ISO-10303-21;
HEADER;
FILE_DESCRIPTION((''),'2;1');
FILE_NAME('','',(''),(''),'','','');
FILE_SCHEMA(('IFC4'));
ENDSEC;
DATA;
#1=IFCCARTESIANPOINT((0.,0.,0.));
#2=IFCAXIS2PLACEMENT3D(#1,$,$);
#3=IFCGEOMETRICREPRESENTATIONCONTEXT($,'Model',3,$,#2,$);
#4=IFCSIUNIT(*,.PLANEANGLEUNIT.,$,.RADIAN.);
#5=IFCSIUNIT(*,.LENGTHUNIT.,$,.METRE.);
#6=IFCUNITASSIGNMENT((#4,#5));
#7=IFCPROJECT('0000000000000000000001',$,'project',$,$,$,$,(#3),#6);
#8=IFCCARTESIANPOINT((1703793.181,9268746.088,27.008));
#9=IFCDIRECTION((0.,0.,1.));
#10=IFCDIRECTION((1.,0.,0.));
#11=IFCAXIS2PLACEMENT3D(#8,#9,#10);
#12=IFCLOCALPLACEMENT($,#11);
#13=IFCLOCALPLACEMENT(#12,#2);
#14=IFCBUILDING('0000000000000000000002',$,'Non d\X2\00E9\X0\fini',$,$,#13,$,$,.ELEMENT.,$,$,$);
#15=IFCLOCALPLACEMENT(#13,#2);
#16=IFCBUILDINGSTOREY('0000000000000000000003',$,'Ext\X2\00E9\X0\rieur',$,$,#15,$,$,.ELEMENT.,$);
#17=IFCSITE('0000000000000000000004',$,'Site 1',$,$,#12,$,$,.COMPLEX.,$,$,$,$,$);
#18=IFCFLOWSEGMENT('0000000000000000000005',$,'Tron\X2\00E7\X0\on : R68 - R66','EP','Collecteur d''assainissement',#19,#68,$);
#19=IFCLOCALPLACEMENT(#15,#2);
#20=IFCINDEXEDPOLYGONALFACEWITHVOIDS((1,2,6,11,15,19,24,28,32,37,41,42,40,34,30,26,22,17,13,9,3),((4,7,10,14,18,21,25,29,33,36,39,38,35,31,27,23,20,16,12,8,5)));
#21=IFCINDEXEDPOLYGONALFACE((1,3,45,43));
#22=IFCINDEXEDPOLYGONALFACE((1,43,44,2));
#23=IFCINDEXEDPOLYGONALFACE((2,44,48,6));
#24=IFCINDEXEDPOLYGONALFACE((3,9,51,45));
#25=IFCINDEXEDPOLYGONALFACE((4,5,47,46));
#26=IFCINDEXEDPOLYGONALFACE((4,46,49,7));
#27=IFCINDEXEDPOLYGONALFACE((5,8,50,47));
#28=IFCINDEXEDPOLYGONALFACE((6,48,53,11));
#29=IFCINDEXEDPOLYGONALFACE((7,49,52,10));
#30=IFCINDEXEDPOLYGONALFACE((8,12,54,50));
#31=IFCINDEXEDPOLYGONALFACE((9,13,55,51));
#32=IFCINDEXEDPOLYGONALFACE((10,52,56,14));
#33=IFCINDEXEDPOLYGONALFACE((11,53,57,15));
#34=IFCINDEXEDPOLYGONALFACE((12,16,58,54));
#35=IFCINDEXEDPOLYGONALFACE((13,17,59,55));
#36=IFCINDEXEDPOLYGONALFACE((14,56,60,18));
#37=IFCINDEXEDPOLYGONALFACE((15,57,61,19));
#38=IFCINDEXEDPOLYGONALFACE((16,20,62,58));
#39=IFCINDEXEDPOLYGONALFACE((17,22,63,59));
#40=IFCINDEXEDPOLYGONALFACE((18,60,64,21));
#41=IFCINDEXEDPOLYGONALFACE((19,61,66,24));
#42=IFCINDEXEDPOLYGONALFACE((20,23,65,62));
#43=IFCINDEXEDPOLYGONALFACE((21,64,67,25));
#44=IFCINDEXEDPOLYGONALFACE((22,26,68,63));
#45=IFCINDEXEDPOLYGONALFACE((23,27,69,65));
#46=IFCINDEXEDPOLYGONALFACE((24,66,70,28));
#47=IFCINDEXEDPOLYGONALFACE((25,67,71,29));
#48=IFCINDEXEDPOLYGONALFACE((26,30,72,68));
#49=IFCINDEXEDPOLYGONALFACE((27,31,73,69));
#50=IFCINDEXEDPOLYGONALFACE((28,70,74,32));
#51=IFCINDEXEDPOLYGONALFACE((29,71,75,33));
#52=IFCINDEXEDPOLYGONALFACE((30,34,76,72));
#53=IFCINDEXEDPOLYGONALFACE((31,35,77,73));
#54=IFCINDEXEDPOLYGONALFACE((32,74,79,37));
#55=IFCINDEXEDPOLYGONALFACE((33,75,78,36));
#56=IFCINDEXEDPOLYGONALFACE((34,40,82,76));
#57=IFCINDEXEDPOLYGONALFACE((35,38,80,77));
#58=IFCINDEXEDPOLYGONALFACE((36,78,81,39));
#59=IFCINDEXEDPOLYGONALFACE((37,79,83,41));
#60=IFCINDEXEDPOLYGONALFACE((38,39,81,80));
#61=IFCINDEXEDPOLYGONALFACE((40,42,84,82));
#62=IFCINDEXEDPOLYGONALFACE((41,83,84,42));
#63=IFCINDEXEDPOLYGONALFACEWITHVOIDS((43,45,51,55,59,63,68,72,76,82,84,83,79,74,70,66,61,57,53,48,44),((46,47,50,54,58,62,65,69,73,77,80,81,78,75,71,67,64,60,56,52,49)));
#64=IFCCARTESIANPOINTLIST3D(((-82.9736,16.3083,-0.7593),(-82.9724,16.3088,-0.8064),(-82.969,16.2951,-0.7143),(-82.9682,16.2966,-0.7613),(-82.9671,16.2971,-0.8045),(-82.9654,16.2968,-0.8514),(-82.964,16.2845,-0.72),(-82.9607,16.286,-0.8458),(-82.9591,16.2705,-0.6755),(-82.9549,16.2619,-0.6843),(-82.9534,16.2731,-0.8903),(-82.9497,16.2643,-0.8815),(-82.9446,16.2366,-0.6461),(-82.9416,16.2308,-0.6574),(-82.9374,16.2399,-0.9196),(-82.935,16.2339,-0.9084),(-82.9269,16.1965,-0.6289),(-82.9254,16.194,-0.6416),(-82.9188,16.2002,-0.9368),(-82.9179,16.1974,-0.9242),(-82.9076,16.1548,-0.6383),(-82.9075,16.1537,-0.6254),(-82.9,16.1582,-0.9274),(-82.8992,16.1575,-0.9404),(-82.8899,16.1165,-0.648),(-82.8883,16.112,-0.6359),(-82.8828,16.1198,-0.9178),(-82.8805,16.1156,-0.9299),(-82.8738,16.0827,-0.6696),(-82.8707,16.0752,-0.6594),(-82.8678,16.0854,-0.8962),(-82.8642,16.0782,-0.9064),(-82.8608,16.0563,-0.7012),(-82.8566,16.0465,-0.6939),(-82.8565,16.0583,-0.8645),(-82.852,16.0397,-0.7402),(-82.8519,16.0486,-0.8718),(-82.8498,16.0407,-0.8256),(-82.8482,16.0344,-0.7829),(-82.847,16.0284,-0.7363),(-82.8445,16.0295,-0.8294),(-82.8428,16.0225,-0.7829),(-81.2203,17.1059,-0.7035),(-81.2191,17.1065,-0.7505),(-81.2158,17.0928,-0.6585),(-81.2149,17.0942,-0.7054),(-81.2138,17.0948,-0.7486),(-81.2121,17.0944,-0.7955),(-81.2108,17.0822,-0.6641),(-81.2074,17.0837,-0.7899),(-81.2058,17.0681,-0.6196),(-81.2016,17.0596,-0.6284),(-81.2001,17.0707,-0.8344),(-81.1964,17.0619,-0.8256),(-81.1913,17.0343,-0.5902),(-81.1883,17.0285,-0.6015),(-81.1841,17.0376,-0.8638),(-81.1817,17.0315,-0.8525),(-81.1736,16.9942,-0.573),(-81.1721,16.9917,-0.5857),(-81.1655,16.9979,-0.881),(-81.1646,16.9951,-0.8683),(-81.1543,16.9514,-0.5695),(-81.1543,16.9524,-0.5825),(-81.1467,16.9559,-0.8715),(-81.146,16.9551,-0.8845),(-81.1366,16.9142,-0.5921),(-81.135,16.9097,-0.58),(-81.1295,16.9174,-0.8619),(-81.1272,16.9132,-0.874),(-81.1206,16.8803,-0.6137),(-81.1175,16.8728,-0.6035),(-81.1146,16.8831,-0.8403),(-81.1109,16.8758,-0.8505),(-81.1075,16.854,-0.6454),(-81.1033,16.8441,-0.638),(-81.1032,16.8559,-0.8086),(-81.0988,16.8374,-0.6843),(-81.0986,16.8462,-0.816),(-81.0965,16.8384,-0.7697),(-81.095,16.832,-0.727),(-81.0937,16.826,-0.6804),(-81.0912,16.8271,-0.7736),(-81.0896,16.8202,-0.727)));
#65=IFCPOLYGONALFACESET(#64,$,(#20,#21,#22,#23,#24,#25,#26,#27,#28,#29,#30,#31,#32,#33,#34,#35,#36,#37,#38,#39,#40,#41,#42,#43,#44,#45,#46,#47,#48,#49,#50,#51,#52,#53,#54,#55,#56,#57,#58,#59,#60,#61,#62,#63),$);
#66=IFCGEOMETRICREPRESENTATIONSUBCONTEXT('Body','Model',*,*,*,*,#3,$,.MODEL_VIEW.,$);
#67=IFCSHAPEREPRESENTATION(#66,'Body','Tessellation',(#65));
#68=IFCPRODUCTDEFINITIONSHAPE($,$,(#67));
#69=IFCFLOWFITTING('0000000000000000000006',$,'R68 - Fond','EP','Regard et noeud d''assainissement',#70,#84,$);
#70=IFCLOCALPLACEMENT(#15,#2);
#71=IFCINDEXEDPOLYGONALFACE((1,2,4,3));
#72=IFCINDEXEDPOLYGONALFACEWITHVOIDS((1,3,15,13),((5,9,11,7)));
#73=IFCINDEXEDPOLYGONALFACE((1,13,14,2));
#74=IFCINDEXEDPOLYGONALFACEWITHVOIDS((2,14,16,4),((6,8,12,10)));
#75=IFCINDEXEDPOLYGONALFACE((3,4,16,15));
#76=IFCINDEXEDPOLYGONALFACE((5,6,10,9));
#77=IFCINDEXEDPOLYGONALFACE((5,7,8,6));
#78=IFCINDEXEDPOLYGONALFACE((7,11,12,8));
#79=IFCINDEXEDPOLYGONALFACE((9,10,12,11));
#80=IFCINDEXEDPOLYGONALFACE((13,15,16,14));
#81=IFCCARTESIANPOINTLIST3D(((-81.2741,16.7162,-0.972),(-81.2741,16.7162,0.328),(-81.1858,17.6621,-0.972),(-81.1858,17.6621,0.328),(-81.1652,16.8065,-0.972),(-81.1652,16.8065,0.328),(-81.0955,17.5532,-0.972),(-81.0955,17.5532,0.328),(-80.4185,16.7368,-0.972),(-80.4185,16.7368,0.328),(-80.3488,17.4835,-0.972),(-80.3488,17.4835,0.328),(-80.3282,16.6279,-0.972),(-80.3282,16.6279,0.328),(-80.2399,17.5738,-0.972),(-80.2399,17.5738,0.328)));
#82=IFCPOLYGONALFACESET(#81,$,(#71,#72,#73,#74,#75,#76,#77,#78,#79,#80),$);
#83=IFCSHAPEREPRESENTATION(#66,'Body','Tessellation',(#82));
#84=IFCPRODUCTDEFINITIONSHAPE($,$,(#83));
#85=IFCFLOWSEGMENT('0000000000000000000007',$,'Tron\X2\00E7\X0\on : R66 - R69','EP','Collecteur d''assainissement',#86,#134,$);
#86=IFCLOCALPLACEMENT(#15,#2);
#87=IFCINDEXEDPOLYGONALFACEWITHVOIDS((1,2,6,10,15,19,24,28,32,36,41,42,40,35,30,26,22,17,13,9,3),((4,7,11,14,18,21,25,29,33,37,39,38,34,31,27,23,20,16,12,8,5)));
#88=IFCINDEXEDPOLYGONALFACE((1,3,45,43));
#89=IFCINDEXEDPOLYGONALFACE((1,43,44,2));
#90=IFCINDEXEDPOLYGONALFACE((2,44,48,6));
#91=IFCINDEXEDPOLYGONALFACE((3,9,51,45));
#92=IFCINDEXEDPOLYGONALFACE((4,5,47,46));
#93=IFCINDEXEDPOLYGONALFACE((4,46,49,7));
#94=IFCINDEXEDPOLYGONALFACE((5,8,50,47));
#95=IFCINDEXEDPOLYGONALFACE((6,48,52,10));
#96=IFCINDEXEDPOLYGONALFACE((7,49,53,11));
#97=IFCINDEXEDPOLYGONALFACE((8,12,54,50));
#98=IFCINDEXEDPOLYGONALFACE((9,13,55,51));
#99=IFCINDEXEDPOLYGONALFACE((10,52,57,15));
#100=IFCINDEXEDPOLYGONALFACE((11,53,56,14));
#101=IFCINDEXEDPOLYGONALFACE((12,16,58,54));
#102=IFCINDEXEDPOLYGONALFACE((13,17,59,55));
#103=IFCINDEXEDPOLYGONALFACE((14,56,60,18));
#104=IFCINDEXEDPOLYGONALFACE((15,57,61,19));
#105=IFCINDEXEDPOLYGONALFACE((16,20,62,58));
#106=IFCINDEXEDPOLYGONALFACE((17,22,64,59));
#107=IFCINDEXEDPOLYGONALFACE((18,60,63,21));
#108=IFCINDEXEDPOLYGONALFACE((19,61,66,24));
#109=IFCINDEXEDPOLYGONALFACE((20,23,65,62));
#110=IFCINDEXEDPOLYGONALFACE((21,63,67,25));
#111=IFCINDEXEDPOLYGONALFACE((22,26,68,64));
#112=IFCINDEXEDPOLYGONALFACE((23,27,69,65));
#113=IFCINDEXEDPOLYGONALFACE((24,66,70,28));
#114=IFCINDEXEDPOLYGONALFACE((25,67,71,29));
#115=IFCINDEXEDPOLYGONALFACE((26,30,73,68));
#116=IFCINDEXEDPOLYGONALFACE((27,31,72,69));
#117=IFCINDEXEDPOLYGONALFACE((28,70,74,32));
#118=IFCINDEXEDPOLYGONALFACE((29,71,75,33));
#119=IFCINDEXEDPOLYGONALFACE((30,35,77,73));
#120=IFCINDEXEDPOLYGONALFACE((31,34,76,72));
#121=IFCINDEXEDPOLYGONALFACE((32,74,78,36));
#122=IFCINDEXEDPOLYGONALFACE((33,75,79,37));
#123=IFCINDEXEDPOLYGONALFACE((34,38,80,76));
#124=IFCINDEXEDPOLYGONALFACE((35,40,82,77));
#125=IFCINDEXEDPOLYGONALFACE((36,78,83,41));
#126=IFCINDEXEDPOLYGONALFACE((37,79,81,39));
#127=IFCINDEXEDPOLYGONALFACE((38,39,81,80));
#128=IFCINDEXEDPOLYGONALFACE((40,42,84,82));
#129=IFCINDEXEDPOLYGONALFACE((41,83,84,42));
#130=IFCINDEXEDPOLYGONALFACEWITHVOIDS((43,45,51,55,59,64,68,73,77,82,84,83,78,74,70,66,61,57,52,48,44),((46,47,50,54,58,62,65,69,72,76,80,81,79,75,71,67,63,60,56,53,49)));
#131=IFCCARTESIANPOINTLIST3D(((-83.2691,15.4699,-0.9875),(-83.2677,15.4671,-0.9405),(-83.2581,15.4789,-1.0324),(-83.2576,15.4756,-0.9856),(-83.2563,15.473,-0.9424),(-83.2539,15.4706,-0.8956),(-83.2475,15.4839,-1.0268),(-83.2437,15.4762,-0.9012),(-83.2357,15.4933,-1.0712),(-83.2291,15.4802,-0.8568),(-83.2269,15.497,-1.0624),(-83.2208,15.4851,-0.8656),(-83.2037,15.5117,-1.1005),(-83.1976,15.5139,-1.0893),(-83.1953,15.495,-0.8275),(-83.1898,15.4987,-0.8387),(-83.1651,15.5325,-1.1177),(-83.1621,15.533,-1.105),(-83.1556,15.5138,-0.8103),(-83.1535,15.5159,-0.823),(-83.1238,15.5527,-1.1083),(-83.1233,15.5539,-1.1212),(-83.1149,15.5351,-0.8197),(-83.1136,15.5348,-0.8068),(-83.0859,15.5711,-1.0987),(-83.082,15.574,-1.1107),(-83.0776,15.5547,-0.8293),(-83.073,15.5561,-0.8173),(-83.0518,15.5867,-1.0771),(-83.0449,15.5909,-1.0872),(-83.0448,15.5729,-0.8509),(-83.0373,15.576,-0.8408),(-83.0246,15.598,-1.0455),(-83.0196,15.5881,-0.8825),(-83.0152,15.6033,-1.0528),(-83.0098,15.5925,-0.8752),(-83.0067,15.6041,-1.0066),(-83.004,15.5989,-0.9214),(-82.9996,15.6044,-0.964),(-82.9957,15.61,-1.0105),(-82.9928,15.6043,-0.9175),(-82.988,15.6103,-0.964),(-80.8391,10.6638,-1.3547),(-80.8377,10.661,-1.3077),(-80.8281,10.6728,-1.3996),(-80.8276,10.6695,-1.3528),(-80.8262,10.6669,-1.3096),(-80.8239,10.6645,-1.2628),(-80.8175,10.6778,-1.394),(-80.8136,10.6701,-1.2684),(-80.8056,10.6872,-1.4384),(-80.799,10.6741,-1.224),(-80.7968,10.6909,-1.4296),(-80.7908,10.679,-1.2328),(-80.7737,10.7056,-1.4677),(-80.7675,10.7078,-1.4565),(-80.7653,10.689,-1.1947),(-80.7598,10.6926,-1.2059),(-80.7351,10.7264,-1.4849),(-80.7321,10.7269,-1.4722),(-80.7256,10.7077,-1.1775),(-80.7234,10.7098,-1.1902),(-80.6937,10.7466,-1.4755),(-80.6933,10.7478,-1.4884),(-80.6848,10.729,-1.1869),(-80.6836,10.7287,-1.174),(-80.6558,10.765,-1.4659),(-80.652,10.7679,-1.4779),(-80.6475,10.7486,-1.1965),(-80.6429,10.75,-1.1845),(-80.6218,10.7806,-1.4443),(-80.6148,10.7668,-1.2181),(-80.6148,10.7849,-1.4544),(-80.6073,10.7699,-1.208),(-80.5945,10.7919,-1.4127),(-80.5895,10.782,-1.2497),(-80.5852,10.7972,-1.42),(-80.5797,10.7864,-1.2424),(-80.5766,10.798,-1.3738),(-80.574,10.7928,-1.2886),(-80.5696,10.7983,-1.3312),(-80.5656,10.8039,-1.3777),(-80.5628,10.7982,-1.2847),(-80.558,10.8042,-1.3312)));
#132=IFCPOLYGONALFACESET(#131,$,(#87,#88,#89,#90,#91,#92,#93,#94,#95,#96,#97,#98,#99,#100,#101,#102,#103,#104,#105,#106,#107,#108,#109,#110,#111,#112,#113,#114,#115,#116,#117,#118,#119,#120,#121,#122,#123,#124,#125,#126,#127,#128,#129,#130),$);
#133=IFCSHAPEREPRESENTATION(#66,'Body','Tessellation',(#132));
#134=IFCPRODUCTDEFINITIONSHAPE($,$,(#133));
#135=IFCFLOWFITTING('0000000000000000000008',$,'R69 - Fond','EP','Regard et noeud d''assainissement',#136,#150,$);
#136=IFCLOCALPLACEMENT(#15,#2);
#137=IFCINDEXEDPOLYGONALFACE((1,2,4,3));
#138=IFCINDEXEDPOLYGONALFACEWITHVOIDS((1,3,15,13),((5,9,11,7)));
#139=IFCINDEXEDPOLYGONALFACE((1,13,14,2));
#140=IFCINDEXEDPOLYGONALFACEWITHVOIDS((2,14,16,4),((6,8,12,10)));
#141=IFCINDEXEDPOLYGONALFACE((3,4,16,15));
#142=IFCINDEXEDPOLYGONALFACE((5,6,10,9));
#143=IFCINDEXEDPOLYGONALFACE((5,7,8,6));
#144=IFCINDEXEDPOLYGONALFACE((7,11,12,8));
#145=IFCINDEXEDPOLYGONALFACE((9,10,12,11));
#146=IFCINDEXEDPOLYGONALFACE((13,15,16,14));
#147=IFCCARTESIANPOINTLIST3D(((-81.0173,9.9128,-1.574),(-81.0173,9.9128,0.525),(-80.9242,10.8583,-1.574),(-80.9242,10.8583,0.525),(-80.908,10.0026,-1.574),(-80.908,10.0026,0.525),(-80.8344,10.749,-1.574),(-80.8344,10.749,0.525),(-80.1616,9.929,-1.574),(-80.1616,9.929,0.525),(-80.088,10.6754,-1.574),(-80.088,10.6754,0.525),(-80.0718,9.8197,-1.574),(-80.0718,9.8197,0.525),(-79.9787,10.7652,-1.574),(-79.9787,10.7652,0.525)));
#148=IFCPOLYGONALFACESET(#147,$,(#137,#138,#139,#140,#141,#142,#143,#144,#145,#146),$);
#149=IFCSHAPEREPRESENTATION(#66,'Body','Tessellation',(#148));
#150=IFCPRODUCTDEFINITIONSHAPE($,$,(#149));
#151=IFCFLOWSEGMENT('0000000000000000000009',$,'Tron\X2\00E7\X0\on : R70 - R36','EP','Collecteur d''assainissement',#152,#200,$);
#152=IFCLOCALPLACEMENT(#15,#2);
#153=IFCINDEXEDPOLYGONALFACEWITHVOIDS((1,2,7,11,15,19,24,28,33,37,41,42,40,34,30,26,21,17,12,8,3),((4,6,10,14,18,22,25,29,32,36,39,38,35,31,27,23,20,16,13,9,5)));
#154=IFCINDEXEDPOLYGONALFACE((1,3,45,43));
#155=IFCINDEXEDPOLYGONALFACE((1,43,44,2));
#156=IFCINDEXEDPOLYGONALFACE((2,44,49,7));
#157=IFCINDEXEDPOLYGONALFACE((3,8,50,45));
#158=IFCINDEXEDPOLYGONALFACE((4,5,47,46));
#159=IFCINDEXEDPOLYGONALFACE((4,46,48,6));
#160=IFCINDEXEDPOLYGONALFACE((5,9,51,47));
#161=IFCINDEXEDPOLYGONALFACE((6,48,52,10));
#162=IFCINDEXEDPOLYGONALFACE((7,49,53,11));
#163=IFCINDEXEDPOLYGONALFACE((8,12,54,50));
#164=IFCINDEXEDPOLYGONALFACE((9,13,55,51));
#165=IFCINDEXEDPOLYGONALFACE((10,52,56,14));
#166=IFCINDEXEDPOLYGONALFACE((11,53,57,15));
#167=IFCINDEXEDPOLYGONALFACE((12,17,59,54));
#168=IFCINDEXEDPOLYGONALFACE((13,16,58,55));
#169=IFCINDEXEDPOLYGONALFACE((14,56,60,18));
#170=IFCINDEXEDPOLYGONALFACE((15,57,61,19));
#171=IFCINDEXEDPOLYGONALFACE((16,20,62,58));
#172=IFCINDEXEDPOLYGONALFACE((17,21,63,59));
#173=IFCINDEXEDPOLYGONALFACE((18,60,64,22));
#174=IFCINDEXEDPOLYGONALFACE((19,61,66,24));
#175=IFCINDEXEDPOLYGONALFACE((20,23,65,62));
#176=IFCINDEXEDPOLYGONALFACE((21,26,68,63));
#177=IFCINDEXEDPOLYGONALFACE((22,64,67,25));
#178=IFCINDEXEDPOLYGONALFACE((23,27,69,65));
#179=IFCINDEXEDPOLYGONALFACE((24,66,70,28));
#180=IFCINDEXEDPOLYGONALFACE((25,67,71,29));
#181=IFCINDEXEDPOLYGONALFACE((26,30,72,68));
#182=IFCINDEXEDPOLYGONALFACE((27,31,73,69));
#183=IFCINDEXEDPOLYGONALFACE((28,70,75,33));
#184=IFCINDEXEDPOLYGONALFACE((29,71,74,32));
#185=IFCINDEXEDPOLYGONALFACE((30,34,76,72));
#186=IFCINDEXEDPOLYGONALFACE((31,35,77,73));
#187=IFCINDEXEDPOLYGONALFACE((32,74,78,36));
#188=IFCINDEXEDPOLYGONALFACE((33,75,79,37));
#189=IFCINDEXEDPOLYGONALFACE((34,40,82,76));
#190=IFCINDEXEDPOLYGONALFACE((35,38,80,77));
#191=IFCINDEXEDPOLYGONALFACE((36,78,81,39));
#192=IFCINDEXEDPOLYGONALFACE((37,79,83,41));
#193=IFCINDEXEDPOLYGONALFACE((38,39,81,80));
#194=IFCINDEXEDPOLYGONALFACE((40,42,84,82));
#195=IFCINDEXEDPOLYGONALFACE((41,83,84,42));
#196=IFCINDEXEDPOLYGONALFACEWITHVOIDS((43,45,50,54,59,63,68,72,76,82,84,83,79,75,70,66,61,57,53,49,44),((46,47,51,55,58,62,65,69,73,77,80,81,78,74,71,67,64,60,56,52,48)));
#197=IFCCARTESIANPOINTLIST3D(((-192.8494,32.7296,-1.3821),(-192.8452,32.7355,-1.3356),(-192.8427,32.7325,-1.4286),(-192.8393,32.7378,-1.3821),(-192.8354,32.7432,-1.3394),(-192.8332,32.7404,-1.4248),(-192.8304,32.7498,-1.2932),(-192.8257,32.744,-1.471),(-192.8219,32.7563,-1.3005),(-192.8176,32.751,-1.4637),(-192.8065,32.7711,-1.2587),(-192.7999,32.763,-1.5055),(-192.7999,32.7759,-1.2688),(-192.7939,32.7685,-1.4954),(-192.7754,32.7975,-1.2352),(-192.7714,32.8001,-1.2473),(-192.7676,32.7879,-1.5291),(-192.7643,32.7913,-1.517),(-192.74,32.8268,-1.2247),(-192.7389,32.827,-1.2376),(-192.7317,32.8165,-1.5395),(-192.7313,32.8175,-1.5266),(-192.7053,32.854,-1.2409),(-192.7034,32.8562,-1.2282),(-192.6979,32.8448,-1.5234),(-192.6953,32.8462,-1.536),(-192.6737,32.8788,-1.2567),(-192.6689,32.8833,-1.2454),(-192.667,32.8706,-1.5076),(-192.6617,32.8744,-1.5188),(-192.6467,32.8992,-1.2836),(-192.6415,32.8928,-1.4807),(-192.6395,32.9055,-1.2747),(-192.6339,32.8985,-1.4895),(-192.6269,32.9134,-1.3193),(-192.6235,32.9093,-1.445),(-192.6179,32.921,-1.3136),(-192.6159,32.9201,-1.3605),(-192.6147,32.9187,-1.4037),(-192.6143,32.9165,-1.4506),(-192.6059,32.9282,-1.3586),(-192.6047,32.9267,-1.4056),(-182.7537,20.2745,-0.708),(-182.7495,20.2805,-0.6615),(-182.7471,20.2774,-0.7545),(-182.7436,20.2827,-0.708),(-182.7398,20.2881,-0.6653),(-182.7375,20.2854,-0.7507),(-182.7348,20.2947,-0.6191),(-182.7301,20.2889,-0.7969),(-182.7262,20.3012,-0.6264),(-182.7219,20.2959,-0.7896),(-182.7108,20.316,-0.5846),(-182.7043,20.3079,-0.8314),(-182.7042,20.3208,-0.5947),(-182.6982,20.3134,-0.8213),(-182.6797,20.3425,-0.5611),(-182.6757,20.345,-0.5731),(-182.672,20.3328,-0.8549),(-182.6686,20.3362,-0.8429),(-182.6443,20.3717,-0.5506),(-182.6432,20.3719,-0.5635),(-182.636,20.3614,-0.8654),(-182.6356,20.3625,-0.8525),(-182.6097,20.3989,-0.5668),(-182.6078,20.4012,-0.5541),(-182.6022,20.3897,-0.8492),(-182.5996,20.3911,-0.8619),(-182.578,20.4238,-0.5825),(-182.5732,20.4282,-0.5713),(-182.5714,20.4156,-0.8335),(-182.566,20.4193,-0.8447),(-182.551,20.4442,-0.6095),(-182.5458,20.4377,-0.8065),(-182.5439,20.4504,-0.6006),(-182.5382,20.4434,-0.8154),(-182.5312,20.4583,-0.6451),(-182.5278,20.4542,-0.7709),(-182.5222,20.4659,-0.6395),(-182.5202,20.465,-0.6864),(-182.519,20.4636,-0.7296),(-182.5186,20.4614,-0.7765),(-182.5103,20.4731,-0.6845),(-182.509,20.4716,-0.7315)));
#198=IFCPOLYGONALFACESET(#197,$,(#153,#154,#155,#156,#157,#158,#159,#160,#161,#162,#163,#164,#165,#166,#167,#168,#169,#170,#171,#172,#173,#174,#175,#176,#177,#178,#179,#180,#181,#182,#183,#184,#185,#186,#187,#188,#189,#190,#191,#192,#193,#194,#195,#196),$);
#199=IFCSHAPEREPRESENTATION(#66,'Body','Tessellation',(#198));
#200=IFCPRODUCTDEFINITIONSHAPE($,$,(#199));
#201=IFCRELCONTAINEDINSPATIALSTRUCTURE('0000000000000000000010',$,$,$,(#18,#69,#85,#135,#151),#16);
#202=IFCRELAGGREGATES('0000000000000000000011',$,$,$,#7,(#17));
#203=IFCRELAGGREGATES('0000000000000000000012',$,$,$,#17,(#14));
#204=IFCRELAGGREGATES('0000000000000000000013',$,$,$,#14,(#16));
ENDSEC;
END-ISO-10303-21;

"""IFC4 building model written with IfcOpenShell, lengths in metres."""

from ifc_helpers import new_model, si_unit, frame, origin, origin_2d, place, context, subcontext, project, spatial, hollow_rectangle, hollow_circle, extrude, element, save


model = new_model("IFC4")

# Units and contexts
model_context = context("Model", 3, world=origin())
body_context = subcontext(model_context, "Body", "Model", "MODEL_VIEW")
ifc_project = project(units=[si_unit("PLANEANGLEUNIT", "RADIAN"), si_unit("LENGTHUNIT", "METRE")], contexts=[model_context])

# Site, building, storey
site_placement = place(None, frame((1703793.181, 9268746.088, 27.008), z_axis=(0.0, 0.0, 1.0), x_axis=(1.0, 0.0, 0.0)))
site = spatial("IfcSite", under=ifc_project, at=site_placement, Name="Site 1", CompositionType="COMPLEX")
building_placement = place(site_placement, origin())
building = spatial("IfcBuilding", under=site, at=building_placement, Name="Non défini", CompositionType="ELEMENT")
storey_placement = place(building_placement, origin())
storey = spatial("IfcBuildingStorey", under=building, at=storey_placement, Name="Extérieur", CompositionType="ELEMENT")

# Flow segment
flow_segment_1_placement = place(storey_placement, origin())
element("IfcFlowSegment", 1, at=flow_segment_1_placement, inside=storey, Name="Tronçon : R68 - R66", Description="EP", ObjectType="Collecteur d'assainissement", context=body_context, shape_type="SweptSolid", body=[
    extrude(hollow_circle(Radius=0.158, WallThickness=0.013, at=origin_2d()), frame((-81.155, 16.964, -0.727), z_axis=(-0.91, -0.414, -0.029), x_axis=(0.414, -0.91, 0.0)), (0.0, 0.0, 1.0), 1.927),
])

# Flow fitting
flow_fitting_1_placement = place(storey_placement, origin())
element("IfcFlowFitting", 2, at=flow_fitting_1_placement, inside=storey, Name="R68 - Fond", Description="EP", ObjectType="Regard et noeud d'assainissement", context=body_context, shape_type="SweptSolid", body=[
    extrude(hollow_rectangle(XDim=0.95, YDim=0.95, WallThickness=0.1, at=origin_2d()), frame((-80.757, 17.145, -0.972), z_axis=(0.0, 0.0, 1.0), x_axis=(0.093, 0.996, 0.0)), (0.0, 0.0, 1.0), 1.3),
])

# Flow segment
flow_segment_2_placement = place(storey_placement, origin())
element("IfcFlowSegment", 3, at=flow_segment_2_placement, inside=storey, Name="Tronçon : R66 - R69", Description="EP", ObjectType="Collecteur d'assainissement", context=body_context, shape_type="SweptSolid", body=[
    extrude(hollow_circle(Radius=0.158, WallThickness=0.013, at=origin_2d()), frame((-83.129, 15.539, -0.964), z_axis=(0.45, -0.89, -0.068), x_axis=(0.892, 0.451, 0.0)), (0.0, 0.0, 1.0), 5.398),
])

# Flow fitting
flow_fitting_2_placement = place(storey_placement, origin())
element("IfcFlowFitting", 4, at=flow_fitting_2_placement, inside=storey, Name="R69 - Fond", Description="EP", ObjectType="Regard et noeud d'assainissement", context=body_context, shape_type="SweptSolid", body=[
    extrude(hollow_rectangle(XDim=0.95, YDim=0.95, WallThickness=0.1, at=origin_2d()), frame((-80.498, 10.339, -1.574), z_axis=(0.0, 0.0, 1.0), x_axis=(-0.098, -0.995, 0.0)), (0.0, 0.0, 1.0), 2.099),
])

# Flow segment
flow_segment_3_placement = place(storey_placement, origin())
element("IfcFlowSegment", 5, at=flow_segment_3_placement, inside=storey, Name="Tronçon : R70 - R36", Description="EP", ObjectType="Collecteur d'assainissement", context=body_context, shape_type="SweptSolid", body=[
    extrude(hollow_circle(Radius=0.158, WallThickness=0.013, at=origin_2d()), frame((-182.631, 20.374, -0.708), z_axis=(-0.629, 0.776, -0.042), x_axis=(-0.777, -0.629, 0.0)), (0.0, 0.0, 1.0), 16.047),
])

save(model, "model.ifc")
